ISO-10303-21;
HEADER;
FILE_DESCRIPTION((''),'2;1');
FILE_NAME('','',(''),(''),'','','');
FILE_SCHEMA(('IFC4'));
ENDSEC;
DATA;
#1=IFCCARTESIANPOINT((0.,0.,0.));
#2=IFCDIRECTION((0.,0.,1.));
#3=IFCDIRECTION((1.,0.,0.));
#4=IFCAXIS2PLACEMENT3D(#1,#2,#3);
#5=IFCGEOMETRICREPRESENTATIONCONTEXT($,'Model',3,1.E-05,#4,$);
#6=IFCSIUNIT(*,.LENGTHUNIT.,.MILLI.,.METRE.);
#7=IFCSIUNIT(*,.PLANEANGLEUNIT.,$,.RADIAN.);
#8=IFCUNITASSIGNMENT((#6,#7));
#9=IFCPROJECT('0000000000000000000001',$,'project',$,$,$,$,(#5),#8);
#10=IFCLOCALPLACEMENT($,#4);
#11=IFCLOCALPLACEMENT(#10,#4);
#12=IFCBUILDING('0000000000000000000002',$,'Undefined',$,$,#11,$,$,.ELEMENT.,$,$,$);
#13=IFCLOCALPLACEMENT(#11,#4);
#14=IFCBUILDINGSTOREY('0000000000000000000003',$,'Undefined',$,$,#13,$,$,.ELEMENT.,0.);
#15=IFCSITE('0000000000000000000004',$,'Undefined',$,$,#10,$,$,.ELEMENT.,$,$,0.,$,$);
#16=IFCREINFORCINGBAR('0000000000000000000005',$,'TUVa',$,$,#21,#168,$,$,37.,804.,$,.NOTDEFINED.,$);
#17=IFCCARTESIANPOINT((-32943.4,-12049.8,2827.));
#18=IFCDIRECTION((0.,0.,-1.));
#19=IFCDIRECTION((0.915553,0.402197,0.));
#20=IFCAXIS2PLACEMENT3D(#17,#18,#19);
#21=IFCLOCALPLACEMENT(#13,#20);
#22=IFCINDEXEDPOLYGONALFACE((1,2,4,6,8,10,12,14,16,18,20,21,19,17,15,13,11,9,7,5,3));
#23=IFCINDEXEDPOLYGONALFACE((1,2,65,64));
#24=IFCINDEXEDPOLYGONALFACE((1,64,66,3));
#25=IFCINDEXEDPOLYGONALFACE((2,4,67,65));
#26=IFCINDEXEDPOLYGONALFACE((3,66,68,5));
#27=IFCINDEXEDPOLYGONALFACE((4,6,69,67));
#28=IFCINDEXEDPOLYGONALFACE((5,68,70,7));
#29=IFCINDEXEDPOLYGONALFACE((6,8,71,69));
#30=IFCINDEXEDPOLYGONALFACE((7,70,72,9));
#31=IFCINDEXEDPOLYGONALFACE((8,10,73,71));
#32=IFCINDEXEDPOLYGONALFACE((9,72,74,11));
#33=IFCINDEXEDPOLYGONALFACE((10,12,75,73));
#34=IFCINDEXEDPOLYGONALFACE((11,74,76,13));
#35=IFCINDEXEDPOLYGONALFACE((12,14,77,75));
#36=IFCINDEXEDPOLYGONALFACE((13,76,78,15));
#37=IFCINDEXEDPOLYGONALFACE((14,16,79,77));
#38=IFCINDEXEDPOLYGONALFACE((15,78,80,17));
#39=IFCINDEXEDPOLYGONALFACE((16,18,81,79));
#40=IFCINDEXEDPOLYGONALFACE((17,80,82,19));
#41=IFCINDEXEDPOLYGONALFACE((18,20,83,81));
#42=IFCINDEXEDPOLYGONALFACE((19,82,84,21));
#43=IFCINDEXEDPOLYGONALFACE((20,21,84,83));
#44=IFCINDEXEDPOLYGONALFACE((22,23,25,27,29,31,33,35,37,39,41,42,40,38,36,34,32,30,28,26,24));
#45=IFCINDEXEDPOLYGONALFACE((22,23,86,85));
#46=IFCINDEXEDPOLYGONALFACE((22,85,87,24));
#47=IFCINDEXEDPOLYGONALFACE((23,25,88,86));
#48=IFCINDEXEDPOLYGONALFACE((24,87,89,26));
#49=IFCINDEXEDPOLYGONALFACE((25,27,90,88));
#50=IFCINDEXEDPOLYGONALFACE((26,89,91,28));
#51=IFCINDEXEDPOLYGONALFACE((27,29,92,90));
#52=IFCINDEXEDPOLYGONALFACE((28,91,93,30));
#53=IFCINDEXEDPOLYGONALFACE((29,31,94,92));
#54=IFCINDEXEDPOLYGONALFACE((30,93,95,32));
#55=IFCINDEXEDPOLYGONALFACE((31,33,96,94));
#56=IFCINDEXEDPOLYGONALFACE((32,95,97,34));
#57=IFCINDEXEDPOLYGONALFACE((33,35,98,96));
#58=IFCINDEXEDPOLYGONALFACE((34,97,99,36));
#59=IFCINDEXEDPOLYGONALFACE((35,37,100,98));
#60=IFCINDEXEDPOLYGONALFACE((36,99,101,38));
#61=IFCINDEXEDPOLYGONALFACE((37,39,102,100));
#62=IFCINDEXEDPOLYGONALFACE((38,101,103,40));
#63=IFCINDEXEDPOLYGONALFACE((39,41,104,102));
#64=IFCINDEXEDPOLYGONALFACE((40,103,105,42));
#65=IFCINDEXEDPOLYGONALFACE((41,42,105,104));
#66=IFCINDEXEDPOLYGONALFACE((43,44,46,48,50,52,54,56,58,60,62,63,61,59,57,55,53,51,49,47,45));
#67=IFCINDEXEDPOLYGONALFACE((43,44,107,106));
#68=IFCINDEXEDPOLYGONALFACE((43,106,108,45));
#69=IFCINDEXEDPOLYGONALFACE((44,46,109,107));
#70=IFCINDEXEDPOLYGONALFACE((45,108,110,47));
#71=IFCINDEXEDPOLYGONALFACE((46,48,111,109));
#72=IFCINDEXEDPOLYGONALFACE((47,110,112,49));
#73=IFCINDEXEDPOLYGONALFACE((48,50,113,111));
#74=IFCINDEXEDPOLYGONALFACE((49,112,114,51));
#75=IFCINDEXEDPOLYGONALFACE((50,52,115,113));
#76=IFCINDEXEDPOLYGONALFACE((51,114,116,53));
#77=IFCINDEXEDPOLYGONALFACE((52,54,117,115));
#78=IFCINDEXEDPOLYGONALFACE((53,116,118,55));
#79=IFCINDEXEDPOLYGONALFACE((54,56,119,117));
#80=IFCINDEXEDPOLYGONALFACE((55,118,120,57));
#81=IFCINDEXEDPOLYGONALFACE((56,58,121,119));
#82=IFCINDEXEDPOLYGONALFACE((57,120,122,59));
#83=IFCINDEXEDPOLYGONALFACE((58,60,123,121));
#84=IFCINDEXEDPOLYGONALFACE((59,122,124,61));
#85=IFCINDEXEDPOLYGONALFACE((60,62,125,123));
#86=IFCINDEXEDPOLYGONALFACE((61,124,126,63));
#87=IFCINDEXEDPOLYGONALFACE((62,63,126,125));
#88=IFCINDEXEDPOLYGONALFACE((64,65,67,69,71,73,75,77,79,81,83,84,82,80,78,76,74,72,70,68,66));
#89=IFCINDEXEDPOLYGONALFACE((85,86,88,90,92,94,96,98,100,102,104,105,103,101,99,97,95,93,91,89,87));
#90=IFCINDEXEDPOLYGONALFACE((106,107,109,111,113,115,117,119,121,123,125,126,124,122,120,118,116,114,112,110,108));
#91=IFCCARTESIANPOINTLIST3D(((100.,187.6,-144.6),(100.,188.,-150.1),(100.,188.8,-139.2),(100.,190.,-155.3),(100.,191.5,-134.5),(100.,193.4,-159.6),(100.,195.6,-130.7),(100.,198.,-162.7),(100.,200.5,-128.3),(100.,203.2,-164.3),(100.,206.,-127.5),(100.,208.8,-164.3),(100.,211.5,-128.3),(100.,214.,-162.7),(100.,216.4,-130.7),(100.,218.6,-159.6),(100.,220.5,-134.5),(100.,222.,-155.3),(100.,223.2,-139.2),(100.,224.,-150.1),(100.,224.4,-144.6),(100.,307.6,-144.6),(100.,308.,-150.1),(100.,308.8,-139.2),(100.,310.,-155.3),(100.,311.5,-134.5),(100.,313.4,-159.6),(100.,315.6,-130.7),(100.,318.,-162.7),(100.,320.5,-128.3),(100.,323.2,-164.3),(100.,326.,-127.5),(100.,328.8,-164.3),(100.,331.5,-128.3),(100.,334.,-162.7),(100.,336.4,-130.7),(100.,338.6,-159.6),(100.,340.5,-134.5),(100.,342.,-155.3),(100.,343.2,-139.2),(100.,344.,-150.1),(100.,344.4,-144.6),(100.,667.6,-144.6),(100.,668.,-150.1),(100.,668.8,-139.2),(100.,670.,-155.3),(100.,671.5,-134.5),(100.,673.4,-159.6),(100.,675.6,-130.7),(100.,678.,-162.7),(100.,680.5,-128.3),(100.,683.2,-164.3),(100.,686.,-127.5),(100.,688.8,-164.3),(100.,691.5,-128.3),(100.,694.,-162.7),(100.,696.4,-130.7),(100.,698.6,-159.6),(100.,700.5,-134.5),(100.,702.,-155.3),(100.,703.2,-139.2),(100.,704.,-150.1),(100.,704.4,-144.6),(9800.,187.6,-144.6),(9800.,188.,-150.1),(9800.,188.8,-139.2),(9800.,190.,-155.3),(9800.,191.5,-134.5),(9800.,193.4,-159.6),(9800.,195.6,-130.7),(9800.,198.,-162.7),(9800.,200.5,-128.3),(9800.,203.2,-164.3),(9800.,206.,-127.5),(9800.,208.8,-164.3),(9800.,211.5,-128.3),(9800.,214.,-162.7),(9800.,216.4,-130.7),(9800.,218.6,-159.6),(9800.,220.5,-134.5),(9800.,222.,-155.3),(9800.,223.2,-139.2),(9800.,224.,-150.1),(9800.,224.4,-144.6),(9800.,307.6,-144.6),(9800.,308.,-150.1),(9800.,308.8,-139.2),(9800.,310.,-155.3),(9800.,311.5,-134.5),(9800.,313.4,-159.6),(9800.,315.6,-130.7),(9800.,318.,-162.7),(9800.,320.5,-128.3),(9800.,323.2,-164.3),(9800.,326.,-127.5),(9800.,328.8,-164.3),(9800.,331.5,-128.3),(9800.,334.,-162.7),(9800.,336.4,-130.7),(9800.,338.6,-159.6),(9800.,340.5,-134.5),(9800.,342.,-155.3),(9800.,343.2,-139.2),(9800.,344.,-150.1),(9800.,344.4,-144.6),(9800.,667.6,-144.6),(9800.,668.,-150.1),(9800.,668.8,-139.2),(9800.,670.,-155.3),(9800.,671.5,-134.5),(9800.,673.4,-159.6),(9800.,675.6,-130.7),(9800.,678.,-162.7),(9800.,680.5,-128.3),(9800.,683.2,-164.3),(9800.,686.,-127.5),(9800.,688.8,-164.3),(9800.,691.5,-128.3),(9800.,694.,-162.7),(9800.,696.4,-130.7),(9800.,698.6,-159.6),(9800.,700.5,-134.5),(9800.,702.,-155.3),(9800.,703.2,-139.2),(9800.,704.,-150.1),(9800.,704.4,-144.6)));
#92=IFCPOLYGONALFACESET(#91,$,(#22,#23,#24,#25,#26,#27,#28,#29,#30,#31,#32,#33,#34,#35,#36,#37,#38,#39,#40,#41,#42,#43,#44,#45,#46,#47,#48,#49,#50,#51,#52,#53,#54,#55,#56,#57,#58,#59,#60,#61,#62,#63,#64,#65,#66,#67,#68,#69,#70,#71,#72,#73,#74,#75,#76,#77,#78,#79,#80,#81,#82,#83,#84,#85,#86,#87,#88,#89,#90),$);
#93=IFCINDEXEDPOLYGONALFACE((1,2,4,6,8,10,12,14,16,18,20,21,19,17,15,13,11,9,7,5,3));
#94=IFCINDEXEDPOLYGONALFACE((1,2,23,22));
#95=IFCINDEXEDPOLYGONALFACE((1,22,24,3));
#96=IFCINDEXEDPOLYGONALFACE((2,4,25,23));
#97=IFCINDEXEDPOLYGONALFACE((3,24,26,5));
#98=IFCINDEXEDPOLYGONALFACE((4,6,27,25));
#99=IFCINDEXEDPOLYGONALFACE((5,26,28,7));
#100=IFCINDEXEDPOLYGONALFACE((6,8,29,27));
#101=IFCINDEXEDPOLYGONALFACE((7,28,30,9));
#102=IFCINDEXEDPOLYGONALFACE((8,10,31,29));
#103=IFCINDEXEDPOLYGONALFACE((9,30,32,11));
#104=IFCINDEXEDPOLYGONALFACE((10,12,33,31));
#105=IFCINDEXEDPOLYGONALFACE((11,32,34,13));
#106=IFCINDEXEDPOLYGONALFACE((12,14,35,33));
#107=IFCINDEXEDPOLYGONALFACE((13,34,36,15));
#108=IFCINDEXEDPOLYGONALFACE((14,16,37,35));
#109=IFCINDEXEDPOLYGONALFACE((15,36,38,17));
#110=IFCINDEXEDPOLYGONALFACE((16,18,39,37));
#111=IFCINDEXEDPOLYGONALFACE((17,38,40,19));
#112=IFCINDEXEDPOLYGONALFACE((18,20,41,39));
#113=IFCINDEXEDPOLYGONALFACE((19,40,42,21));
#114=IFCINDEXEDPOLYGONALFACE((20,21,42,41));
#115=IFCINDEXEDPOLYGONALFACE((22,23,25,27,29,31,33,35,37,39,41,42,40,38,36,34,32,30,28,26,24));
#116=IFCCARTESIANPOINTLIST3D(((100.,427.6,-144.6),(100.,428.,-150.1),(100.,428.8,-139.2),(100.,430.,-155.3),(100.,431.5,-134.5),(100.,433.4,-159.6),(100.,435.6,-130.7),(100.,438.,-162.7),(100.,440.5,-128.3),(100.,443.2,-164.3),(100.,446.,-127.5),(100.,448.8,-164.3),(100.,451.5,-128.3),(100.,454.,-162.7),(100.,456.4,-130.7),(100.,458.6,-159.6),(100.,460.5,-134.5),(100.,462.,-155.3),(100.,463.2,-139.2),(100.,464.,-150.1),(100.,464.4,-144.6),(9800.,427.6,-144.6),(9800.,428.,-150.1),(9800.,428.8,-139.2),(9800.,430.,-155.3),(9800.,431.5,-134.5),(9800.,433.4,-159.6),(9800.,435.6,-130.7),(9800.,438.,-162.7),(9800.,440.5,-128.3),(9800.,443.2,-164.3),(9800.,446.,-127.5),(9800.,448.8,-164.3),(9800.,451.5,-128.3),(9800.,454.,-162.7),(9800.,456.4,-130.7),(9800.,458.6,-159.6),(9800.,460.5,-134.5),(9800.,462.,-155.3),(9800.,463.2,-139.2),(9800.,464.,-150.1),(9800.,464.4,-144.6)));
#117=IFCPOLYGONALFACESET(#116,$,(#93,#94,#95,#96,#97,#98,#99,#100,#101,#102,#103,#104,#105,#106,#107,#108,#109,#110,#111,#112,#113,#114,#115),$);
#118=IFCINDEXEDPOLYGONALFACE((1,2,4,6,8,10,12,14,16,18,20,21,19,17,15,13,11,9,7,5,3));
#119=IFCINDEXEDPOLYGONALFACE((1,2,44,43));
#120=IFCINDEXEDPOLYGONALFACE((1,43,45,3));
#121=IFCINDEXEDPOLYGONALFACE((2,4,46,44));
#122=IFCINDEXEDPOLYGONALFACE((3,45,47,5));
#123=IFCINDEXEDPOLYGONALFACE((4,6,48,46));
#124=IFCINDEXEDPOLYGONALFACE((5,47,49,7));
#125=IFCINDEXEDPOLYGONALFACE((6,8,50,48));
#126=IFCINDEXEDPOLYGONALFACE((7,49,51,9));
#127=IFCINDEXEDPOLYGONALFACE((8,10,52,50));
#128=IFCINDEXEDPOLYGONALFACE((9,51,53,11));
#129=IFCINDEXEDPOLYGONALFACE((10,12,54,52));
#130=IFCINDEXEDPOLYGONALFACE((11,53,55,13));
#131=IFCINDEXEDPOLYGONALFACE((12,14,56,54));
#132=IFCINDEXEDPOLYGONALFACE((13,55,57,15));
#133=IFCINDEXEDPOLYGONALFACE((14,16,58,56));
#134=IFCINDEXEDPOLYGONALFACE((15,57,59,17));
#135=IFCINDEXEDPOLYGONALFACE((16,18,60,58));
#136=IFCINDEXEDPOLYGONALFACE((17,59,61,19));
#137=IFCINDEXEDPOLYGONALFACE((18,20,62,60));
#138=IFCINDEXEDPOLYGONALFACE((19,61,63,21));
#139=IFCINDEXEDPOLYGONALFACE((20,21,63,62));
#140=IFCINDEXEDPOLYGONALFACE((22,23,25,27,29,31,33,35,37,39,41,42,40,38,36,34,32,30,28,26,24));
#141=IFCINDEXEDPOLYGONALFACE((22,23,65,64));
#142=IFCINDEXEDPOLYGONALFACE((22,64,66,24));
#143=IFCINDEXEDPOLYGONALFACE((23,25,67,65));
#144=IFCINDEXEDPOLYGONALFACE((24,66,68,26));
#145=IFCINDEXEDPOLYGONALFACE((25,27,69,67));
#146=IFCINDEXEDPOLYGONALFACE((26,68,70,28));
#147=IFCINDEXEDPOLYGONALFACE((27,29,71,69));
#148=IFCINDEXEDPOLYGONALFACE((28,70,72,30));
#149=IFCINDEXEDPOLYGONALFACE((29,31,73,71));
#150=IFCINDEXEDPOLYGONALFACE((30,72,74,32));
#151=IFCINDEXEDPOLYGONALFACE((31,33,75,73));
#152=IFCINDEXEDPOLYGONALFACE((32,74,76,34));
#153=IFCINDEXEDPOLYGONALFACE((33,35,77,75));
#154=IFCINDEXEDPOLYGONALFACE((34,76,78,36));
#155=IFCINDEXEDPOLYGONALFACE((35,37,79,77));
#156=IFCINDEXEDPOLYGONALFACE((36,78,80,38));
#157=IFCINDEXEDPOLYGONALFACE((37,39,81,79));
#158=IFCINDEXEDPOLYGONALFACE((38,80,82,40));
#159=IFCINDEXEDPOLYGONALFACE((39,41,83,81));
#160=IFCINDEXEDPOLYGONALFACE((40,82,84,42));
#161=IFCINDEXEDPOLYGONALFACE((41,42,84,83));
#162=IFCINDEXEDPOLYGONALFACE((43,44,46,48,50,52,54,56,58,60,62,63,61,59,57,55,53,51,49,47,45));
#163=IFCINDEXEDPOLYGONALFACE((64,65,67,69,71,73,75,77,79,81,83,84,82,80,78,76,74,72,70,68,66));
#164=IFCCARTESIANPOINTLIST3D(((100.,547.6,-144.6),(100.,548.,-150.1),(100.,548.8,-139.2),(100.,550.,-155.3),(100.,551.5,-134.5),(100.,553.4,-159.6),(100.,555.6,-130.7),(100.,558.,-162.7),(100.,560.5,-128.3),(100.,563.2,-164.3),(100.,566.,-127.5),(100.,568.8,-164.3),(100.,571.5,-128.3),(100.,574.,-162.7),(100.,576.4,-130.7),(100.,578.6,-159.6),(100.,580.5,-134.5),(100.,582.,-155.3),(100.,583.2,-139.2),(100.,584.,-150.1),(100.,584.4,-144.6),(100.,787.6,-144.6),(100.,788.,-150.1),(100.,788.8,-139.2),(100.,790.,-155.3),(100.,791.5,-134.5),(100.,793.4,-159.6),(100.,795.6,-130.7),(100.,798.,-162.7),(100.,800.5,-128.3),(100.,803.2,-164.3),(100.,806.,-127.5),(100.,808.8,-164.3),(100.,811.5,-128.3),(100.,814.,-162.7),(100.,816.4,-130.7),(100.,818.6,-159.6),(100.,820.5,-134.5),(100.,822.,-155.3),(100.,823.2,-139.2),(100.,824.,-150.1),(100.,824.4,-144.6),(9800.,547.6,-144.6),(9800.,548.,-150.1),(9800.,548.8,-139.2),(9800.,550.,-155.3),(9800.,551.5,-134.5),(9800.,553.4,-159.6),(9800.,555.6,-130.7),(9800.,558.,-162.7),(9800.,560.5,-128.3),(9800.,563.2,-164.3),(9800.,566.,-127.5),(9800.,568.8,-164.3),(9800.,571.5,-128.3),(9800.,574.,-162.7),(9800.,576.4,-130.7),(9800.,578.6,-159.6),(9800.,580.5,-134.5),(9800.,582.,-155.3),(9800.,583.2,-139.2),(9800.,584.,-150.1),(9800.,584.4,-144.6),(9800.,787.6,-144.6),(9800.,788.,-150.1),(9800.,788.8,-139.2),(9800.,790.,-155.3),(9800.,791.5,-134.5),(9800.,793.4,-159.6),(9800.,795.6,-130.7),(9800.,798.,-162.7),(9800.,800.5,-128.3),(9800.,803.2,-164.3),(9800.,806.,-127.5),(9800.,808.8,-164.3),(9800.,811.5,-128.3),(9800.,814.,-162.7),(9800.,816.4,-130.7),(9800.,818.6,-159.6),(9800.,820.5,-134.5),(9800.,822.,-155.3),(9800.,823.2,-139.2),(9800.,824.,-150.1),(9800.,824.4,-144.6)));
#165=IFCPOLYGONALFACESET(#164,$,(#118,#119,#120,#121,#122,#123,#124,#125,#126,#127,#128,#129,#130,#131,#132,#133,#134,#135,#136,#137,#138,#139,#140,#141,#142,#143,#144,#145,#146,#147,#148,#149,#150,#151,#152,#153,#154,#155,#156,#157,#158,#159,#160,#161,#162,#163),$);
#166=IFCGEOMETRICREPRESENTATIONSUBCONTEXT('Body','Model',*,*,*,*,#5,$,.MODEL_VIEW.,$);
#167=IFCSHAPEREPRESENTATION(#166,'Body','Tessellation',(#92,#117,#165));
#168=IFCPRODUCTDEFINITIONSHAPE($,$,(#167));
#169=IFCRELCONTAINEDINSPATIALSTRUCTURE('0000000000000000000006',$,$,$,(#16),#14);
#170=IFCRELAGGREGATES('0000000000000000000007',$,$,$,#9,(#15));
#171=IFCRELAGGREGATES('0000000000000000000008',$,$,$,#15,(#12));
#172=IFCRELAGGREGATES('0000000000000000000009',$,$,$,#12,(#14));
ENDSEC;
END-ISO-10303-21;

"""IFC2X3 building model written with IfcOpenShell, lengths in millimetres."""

from ifc_helpers import new_model, entity, si_unit, frame, origin_with_axes, place, context, subcontext, project, spatial, source, transform, mapped, element, save


model = new_model("IFC2X3")

# Units and contexts
model_context = context("Model", 3, precision=1e-05, world=origin_with_axes())
body_context = subcontext(model_context, "Body", "Model", "MODEL_VIEW")
ifc_project = project(units=[si_unit("LENGTHUNIT", "METRE", prefix="MILLI"), si_unit("PLANEANGLEUNIT", "RADIAN")], contexts=[model_context])

# Site, building, storey
site_placement = place(None, origin_with_axes())
site = spatial("IfcSite", under=ifc_project, at=site_placement, Name="Undefined", CompositionType="ELEMENT", RefElevation=0.0)
building_placement = place(site_placement, origin_with_axes())
building = spatial("IfcBuilding", under=site, at=building_placement, Name="Undefined", CompositionType="ELEMENT")
storey_placement = place(building_placement, origin_with_axes())
storey = spatial("IfcBuildingStorey", under=building, at=storey_placement, Name="Undefined", CompositionType="ELEMENT", Elevation=0.0)

# Reinforcing bar
shared_shape_1 = source(origin_with_axes(), body_context, "Body", "AdvancedSweptSolid", [
    entity("IfcSweptDiskSolid", entity("IfcTrimmedCurve", entity("IfcLine", entity("IfcCartesianPoint", [0.0, 0.0, 0.0]), entity("IfcVector", entity("IfcDirection", [1.0, 0.0, 0.0]), 1.0)), [entity("IfcParameterValue", 0.0)], [entity("IfcParameterValue", 9700.0)], True, "PARAMETER"), 18.5, None, 0.0, 9700.0),
])
shared_shape_2 = source(origin_with_axes(), body_context, "Body", "AdvancedSweptSolid", [
    entity("IfcSweptDiskSolid", entity("IfcTrimmedCurve", entity("IfcLine", entity("IfcCartesianPoint", [0.0, 0.0, 0.0]), entity("IfcVector", entity("IfcDirection", [1.0, 0.0, 0.0]), 1.0)), [entity("IfcParameterValue", 0.0)], [entity("IfcParameterValue", 9700.0)], True, "PARAMETER"), 18.5, None, 0.0, 9700.0),
])
shared_shape_3 = source(origin_with_axes(), body_context, "Body", "AdvancedSweptSolid", [
    entity("IfcSweptDiskSolid", entity("IfcTrimmedCurve", entity("IfcLine", entity("IfcCartesianPoint", [0.0, 0.0, 0.0]), entity("IfcVector", entity("IfcDirection", [1.0, 0.0, 0.0]), 1.0)), [entity("IfcParameterValue", 0.0)], [entity("IfcParameterValue", 9700.0)], True, "PARAMETER"), 18.5, None, 0.0, 9700.0),
])
shared_shape_4 = source(origin_with_axes(), body_context, "Body", "AdvancedSweptSolid", [
    entity("IfcSweptDiskSolid", entity("IfcTrimmedCurve", entity("IfcLine", entity("IfcCartesianPoint", [0.0, 0.0, 0.0]), entity("IfcVector", entity("IfcDirection", [1.0, 0.0, 0.0]), 1.0)), [entity("IfcParameterValue", 0.0)], [entity("IfcParameterValue", 9700.0)], True, "PARAMETER"), 18.5, None, 0.0, 9700.0),
])
shared_shape_5 = source(origin_with_axes(), body_context, "Body", "AdvancedSweptSolid", [
    entity("IfcSweptDiskSolid", entity("IfcTrimmedCurve", entity("IfcLine", entity("IfcCartesianPoint", [0.0, 0.0, 0.0]), entity("IfcVector", entity("IfcDirection", [1.0, 0.0, 0.0]), 1.0)), [entity("IfcParameterValue", 0.0)], [entity("IfcParameterValue", 9700.0)], True, "PARAMETER"), 18.5, None, 0.0, 9700.0),
])
shared_shape_6 = source(origin_with_axes(), body_context, "Body", "AdvancedSweptSolid", [
    entity("IfcSweptDiskSolid", entity("IfcTrimmedCurve", entity("IfcLine", entity("IfcCartesianPoint", [0.0, 0.0, 0.0]), entity("IfcVector", entity("IfcDirection", [1.0, 0.0, 0.0]), 1.0)), [entity("IfcParameterValue", 0.0)], [entity("IfcParameterValue", 9700.0)], True, "PARAMETER"), 18.5, None, 0.0, 9700.0),
])
reinforcing_bar_1_placement = place(storey_placement, frame((-32943.4, -12049.8, 2827.0), z_axis=(0.0, 0.0, -1.0), x_axis=(0.915553, 0.402197, 0.0)))
element("IfcReinforcingBar", 1, at=reinforcing_bar_1_placement, inside=storey, Name="TUVa", BarRole="NOTDEFINED", CrossSectionArea=804.0, NominalDiameter=37.0, context=body_context, shape_type="MappedRepresentation", body=[
    mapped(shared_shape_1, transform((100.0, 206.0, -146.0))),
    mapped(shared_shape_2, transform((100.0, 326.0, -146.0))),
    mapped(shared_shape_3, transform((100.0, 446.0, -146.0))),
    mapped(shared_shape_4, transform((100.0, 566.0, -146.0))),
    mapped(shared_shape_5, transform((100.0, 686.0, -146.0))),
    mapped(shared_shape_6, transform((100.0, 806.0, -146.0))),
])

save(model, "model.ifc")
